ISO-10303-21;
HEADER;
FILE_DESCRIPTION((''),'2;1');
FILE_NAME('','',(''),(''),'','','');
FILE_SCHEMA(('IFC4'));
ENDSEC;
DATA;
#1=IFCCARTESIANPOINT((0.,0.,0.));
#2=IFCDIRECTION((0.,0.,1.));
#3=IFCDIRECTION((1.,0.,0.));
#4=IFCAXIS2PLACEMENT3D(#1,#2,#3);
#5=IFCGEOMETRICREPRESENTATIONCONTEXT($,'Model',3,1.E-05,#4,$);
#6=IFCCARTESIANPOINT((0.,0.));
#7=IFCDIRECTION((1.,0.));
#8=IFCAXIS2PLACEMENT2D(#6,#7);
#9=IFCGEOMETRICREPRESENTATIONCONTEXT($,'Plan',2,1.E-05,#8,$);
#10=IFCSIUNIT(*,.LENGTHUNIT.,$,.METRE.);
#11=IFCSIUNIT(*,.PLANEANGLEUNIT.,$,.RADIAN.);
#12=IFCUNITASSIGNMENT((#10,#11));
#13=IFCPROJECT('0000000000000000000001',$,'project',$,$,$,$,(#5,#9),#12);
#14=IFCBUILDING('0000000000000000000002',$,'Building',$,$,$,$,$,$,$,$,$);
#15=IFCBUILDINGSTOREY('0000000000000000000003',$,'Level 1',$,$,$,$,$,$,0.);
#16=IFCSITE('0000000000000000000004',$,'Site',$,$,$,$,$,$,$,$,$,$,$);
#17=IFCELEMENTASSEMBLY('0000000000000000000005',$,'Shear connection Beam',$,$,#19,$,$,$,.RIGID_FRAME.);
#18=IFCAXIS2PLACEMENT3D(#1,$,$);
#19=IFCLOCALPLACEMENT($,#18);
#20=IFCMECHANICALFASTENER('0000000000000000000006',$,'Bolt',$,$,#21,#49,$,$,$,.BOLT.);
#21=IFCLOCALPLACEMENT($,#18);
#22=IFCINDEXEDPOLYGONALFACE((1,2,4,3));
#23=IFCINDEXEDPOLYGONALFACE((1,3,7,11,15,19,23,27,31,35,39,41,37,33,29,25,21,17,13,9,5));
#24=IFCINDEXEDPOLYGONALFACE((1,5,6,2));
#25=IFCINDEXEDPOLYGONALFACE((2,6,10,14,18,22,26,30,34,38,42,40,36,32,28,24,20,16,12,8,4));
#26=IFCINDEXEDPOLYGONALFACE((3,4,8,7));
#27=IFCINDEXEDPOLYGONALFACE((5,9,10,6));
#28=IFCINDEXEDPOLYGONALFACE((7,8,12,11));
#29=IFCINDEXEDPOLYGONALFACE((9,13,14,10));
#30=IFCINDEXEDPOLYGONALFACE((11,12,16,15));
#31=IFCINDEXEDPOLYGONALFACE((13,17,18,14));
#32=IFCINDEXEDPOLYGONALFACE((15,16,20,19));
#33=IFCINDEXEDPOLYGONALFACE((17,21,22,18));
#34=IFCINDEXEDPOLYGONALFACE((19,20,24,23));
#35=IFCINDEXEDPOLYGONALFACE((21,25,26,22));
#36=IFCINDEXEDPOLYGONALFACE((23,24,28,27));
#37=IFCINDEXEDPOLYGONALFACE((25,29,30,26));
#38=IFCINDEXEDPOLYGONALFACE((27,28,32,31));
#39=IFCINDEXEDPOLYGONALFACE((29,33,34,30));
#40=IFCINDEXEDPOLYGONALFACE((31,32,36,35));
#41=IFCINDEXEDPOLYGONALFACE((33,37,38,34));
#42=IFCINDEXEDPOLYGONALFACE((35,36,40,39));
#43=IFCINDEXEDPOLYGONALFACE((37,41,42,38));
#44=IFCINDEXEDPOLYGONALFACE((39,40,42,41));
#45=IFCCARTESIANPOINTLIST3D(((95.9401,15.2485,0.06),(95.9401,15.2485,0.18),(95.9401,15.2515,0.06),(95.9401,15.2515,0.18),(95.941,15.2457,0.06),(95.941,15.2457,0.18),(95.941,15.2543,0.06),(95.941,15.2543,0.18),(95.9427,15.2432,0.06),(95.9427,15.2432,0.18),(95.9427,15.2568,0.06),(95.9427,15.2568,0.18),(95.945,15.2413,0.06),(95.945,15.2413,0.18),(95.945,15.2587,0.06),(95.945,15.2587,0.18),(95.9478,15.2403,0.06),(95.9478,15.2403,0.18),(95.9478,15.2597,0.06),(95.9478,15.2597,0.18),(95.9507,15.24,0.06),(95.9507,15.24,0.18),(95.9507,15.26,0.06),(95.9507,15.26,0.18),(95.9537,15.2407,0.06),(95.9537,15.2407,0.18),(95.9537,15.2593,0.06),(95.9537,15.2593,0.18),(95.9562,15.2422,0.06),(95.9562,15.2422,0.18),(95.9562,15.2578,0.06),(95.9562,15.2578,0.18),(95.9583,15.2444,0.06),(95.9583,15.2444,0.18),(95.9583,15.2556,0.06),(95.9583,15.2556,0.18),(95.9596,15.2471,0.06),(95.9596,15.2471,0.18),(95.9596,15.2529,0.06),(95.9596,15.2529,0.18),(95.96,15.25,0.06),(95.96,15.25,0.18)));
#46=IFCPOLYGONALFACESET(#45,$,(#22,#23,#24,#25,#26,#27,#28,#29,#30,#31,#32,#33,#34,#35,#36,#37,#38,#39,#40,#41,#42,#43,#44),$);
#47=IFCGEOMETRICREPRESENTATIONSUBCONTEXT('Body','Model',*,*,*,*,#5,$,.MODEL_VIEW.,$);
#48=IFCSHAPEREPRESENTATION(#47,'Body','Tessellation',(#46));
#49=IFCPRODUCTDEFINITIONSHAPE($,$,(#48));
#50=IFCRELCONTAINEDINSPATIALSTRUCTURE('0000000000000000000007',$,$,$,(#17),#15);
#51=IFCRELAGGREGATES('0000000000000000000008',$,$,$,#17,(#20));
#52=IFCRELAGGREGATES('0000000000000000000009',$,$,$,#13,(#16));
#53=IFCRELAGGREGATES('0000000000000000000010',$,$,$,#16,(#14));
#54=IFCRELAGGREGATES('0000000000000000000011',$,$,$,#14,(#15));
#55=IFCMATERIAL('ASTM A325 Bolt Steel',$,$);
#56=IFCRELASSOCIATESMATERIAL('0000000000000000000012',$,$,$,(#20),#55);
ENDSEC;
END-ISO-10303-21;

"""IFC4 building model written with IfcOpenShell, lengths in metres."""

from ifc_helpers import new_model, si_unit, frame, origin_with_axes, origin_2d, origin_2d_with_axis, place, context, subcontext, project, spatial, circle, extrude, material, element, aggregate, save


model = new_model("IFC4")

# Units and contexts
model_context = context("Model", 3, precision=1e-05, world=origin_with_axes())
plan_context = context("Plan", 2, precision=1e-05, world=origin_2d_with_axis())
body_context = subcontext(model_context, "Body", "Model", "MODEL_VIEW")
ifc_project = project(units=[si_unit("LENGTHUNIT", "METRE"), si_unit("PLANEANGLEUNIT", "RADIAN")], contexts=[model_context, plan_context])

# Site, building, storey
site = spatial("IfcSite", under=ifc_project, Name="Site")
building = spatial("IfcBuilding", under=site, Name="Building")
storey = spatial("IfcBuildingStorey", under=building, Name="Level 1", Elevation=0.0)

# Element assembly
assembly_1 = element("IfcElementAssembly", 1, inside=storey, Name="Shear connection Beam", PredefinedType="RIGID_FRAME")

# Mechanical fastener
ifc_material_1 = material(Name="ASTM A325 Bolt Steel")
mechanical_fastener_1_placement = place(None, frame((95.95, 15.25, 0.06), z_axis=(0.0, 0.0, 1.0), x_axis=(1.0, 0.0, 0.0)))
mechanical_fastener_1 = element("IfcMechanicalFastener", 2, at=mechanical_fastener_1_placement, material=ifc_material_1, Name="Bolt", PredefinedType="BOLT", context=body_context, shape_type="SweptSolid", body=[
    extrude(circle(Radius=0.01, at=origin_2d()), origin_with_axes(), (0.0, 0.0, 1.0), 0.12),
])
aggregate(assembly_1, [mechanical_fastener_1])

save(model, "model.ifc")
